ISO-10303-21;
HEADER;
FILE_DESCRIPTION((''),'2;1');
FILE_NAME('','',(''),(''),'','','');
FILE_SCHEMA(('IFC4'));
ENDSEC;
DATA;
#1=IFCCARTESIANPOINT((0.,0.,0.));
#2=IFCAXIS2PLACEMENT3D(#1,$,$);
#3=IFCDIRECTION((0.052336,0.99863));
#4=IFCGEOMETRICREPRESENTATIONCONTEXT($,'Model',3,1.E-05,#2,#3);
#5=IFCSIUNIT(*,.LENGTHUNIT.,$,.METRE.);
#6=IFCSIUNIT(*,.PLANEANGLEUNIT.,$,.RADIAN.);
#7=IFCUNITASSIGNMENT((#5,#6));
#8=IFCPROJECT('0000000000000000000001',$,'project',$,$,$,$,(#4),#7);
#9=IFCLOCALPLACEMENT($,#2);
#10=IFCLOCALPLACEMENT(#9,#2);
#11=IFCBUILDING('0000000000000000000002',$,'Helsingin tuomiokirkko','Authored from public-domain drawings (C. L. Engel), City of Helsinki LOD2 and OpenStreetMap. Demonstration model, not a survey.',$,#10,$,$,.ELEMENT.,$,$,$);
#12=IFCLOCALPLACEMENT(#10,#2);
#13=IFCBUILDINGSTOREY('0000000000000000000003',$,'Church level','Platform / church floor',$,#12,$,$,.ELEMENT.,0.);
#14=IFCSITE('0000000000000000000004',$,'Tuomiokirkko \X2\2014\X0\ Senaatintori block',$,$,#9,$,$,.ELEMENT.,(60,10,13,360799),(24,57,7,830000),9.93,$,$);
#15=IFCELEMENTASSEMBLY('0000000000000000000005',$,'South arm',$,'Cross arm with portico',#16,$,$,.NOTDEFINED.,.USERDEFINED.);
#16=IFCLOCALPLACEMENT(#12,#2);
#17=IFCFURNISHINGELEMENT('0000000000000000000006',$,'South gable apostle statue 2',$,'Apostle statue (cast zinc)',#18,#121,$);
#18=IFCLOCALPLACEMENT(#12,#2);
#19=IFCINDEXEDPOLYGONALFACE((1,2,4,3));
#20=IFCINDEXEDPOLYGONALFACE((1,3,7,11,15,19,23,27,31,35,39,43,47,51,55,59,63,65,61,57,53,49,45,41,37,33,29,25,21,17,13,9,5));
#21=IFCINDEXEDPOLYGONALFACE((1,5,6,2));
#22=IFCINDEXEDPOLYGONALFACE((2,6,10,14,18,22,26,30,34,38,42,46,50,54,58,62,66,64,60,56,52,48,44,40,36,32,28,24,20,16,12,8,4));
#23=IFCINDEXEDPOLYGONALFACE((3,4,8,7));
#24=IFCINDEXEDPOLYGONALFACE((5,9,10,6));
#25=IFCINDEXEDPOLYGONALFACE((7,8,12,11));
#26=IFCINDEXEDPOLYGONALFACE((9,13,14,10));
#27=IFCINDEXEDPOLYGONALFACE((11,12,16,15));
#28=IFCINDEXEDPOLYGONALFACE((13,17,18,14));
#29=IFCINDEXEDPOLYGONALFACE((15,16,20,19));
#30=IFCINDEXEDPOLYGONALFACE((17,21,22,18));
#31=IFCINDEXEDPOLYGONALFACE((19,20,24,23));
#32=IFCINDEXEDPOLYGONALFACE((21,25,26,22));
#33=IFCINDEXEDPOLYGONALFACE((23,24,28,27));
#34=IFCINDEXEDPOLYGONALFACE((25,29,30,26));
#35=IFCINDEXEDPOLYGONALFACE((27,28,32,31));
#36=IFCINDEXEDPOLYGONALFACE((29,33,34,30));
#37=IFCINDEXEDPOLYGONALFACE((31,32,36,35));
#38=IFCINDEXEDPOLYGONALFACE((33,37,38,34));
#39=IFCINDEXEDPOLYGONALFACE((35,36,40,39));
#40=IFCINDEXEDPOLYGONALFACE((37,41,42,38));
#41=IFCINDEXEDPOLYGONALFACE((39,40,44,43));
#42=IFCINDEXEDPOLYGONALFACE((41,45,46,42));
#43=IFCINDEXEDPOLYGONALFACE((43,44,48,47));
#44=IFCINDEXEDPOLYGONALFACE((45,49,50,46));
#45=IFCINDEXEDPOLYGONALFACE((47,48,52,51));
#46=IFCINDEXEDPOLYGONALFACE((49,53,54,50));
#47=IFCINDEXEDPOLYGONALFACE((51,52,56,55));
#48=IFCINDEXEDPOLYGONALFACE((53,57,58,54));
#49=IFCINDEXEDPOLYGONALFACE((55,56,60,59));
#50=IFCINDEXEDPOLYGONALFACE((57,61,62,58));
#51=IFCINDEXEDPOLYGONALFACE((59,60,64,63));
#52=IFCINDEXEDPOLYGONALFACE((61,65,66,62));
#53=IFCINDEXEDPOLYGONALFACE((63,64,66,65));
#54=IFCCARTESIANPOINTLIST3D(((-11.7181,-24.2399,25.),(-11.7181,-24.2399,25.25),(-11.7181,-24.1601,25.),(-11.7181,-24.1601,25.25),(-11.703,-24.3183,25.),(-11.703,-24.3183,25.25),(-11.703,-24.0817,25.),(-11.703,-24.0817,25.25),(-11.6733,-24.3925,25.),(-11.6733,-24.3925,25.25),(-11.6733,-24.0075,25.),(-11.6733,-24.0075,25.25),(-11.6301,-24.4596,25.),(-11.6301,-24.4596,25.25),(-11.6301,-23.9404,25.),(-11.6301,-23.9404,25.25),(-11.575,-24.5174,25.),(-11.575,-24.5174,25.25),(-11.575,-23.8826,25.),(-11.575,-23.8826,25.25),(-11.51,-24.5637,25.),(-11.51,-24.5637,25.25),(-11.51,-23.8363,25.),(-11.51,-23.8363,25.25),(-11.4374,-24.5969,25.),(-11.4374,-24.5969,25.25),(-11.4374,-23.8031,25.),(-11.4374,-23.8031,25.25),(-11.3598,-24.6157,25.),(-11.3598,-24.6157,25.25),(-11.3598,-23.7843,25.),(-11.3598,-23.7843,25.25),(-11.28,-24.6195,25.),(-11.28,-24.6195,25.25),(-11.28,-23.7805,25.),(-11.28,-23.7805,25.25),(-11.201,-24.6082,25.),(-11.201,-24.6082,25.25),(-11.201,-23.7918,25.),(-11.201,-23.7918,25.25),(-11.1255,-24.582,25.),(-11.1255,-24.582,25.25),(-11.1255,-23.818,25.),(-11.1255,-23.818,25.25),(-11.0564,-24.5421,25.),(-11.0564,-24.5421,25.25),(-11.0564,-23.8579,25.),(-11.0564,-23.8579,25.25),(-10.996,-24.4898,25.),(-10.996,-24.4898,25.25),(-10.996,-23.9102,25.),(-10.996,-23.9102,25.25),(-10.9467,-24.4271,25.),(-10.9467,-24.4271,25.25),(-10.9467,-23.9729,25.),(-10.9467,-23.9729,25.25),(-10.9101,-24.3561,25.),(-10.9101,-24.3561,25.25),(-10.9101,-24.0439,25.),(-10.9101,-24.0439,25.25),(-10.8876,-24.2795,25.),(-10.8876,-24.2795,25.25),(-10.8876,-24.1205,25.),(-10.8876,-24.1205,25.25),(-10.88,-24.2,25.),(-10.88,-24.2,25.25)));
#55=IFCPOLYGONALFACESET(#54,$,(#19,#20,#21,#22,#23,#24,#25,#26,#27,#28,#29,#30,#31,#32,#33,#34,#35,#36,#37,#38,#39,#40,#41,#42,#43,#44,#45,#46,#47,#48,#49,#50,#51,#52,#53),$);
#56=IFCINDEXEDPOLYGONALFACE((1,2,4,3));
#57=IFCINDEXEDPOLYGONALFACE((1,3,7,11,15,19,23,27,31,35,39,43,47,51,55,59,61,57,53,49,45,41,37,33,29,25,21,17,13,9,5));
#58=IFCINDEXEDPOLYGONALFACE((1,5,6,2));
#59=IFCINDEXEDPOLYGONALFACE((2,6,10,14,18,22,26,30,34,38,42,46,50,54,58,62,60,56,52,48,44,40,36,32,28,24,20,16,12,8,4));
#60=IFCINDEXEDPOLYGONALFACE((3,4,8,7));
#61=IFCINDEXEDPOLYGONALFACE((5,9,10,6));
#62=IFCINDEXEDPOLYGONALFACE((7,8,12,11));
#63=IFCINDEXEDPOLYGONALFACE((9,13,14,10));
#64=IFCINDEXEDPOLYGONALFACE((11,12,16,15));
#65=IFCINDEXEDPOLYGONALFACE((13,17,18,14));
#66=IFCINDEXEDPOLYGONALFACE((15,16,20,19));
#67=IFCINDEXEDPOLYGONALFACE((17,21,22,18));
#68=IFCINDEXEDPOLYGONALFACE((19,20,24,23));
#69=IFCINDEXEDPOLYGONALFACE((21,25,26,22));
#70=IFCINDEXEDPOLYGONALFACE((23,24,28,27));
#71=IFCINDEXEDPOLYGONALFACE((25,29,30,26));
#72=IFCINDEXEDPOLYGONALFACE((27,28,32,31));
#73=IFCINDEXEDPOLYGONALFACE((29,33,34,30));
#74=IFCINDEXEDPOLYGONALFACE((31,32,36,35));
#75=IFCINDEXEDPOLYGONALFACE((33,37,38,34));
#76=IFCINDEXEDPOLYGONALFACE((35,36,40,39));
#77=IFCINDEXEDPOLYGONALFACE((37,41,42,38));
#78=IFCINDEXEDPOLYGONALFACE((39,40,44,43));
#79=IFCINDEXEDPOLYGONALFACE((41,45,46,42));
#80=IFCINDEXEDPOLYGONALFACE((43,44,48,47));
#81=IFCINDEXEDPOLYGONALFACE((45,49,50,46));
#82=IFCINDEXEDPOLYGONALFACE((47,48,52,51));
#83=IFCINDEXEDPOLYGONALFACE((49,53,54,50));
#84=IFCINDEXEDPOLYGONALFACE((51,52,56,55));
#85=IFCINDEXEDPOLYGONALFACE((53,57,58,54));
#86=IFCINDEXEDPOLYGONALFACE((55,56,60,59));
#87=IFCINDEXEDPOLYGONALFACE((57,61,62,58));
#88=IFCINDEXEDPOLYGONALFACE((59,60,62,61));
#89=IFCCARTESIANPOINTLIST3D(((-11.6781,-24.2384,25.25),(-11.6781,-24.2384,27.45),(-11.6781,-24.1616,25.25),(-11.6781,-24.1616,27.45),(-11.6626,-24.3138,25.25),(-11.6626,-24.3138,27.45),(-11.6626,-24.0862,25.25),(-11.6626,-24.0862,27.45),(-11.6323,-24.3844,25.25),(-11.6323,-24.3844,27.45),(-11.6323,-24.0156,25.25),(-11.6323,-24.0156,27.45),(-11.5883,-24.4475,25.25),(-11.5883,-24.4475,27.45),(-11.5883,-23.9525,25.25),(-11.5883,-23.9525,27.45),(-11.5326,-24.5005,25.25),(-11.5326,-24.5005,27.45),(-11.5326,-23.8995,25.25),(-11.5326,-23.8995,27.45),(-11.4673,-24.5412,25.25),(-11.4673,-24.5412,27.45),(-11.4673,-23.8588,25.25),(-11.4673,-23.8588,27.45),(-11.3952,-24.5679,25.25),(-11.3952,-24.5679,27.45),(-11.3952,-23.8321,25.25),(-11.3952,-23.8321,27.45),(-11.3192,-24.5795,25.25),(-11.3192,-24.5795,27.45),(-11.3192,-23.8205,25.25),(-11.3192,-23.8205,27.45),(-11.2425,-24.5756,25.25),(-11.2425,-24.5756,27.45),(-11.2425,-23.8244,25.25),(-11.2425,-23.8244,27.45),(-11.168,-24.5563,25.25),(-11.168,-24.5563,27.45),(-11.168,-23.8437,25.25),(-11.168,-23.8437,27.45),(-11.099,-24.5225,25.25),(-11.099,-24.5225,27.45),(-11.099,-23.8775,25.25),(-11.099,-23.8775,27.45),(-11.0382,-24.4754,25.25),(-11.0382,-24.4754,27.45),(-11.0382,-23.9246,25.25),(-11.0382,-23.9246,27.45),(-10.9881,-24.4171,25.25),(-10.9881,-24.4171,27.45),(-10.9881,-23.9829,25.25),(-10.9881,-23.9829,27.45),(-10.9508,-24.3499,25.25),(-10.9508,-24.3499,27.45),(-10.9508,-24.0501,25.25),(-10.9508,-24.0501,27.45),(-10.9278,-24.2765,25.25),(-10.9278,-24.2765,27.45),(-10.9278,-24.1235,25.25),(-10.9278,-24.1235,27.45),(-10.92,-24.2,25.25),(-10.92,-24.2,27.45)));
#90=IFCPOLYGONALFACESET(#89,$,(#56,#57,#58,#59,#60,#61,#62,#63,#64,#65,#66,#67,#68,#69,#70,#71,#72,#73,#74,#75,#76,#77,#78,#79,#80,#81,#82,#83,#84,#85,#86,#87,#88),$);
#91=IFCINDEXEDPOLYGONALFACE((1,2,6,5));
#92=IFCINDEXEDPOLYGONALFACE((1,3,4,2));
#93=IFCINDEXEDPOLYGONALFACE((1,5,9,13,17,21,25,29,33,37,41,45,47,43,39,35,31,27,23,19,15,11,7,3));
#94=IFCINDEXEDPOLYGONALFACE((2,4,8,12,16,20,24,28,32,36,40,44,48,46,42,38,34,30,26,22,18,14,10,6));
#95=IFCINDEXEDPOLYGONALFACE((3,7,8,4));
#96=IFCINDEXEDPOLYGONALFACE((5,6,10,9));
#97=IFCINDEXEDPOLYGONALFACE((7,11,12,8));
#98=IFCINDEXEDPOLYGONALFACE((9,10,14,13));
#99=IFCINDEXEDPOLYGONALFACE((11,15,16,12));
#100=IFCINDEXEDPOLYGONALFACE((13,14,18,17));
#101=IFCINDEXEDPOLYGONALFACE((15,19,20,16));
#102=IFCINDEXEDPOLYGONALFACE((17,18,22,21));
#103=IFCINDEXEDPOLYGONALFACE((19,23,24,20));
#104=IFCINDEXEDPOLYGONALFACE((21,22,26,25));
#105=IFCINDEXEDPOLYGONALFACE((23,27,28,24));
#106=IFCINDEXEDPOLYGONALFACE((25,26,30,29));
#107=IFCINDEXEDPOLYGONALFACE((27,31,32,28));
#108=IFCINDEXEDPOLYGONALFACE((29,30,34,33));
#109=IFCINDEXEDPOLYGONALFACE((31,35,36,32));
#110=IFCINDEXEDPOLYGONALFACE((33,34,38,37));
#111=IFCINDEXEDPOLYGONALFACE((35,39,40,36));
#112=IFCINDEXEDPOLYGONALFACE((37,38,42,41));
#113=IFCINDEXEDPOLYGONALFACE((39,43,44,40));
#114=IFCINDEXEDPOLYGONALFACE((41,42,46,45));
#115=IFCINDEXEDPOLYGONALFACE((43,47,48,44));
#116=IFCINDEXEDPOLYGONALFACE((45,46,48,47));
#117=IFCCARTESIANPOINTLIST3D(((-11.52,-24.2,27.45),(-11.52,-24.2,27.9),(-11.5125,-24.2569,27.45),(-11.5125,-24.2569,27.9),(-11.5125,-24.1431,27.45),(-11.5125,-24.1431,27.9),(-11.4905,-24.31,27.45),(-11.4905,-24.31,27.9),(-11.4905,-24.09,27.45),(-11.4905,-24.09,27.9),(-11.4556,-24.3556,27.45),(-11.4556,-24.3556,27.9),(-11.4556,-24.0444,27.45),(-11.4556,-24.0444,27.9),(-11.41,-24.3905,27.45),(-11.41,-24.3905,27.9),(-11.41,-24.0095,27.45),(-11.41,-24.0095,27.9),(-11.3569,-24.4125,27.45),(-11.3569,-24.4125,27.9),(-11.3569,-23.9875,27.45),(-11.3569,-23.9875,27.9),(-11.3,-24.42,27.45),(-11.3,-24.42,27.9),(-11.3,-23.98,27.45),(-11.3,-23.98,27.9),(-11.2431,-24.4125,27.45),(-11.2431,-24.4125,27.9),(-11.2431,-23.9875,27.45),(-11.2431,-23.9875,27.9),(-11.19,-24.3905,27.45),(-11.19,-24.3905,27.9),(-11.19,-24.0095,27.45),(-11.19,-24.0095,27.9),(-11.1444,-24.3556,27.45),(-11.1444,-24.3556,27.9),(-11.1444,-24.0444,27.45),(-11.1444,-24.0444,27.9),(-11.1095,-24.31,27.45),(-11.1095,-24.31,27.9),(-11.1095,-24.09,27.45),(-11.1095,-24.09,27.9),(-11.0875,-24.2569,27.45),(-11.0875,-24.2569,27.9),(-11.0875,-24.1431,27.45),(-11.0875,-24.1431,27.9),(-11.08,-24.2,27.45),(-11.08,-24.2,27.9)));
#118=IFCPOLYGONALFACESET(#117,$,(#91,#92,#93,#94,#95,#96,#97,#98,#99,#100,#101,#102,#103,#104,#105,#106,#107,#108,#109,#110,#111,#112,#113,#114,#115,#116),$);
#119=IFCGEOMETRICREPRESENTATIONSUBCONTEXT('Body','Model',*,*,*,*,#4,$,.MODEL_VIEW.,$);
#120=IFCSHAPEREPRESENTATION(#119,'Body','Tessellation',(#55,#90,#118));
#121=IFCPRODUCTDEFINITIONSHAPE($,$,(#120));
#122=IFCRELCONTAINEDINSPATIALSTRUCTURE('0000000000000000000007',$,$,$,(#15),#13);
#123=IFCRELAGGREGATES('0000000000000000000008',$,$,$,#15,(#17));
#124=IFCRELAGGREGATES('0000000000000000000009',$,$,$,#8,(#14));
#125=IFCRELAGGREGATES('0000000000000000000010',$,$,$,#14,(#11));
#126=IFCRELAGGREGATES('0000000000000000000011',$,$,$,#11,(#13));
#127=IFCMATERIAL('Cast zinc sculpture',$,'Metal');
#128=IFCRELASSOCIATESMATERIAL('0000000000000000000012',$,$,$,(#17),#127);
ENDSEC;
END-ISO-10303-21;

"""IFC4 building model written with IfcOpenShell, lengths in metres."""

from ifc_helpers import new_model, si_unit, direction, frame, origin, origin_2d_with_axis, place, context, subcontext, project, spatial, circle, extrude, material, element, aggregate, save


model = new_model("IFC4")

# Units and contexts
model_context = context("Model", 3, precision=1e-05, world=origin(), true_north=direction((0.052336, 0.99863)))
body_context = subcontext(model_context, "Body", "Model", "MODEL_VIEW")
ifc_project = project(units=[si_unit("LENGTHUNIT", "METRE"), si_unit("PLANEANGLEUNIT", "RADIAN")], contexts=[model_context])

# Site, building, storey
site_placement = place(None, origin())
site = spatial("IfcSite", under=ifc_project, at=site_placement, Name="Tuomiokirkko — Senaatintori block", CompositionType="ELEMENT", RefLatitude=(60, 10, 13, 360799), RefLongitude=(24, 57, 7, 830000), RefElevation=9.93)
building_placement = place(site_placement, origin())
building = spatial("IfcBuilding", under=site, at=building_placement, Name="Helsingin tuomiokirkko", Description="Authored from public-domain drawings (C. L. Engel), City of Helsinki LOD2 and OpenStreetMap. Demonstration model, not a survey.", CompositionType="ELEMENT")
storey_placement = place(building_placement, origin())
storey = spatial("IfcBuildingStorey", under=building, at=storey_placement, Name="Church level", Description="Platform / church floor", CompositionType="ELEMENT", Elevation=0.0)

# Element assembly
assembly_1_placement = place(building_placement, origin())
assembly_1 = element("IfcElementAssembly", 1, at=assembly_1_placement, inside=storey, Name="South arm", ObjectType="Cross arm with portico", AssemblyPlace="NOTDEFINED", PredefinedType="USERDEFINED")

# Furnishing element
ifc_material_1 = material(Name="Cast zinc sculpture", Category="Metal")
furnishing_1_placement = place(building_placement, origin())
furnishing_1 = element("IfcFurnishingElement", 2, at=furnishing_1_placement, material=ifc_material_1, Name="South gable apostle statue 2", ObjectType="Apostle statue (cast zinc)", context=body_context, shape_type="SweptSolid", body=[
    extrude(circle(Radius=0.42, at=origin_2d_with_axis()), frame((-11.3, -24.2, 25.0)), (0.0, 0.0, 1.0), 0.25),
    extrude(circle(Radius=0.38, at=origin_2d_with_axis()), frame((-11.3, -24.2, 25.25)), (0.0, 0.0, 1.0), 2.2),
    extrude(circle(Radius=0.22, at=origin_2d_with_axis()), frame((-11.3, -24.2, 27.45)), (0.0, 0.0, 1.0), 0.45),
])
aggregate(assembly_1, [furnishing_1])

save(model, "model.ifc")
